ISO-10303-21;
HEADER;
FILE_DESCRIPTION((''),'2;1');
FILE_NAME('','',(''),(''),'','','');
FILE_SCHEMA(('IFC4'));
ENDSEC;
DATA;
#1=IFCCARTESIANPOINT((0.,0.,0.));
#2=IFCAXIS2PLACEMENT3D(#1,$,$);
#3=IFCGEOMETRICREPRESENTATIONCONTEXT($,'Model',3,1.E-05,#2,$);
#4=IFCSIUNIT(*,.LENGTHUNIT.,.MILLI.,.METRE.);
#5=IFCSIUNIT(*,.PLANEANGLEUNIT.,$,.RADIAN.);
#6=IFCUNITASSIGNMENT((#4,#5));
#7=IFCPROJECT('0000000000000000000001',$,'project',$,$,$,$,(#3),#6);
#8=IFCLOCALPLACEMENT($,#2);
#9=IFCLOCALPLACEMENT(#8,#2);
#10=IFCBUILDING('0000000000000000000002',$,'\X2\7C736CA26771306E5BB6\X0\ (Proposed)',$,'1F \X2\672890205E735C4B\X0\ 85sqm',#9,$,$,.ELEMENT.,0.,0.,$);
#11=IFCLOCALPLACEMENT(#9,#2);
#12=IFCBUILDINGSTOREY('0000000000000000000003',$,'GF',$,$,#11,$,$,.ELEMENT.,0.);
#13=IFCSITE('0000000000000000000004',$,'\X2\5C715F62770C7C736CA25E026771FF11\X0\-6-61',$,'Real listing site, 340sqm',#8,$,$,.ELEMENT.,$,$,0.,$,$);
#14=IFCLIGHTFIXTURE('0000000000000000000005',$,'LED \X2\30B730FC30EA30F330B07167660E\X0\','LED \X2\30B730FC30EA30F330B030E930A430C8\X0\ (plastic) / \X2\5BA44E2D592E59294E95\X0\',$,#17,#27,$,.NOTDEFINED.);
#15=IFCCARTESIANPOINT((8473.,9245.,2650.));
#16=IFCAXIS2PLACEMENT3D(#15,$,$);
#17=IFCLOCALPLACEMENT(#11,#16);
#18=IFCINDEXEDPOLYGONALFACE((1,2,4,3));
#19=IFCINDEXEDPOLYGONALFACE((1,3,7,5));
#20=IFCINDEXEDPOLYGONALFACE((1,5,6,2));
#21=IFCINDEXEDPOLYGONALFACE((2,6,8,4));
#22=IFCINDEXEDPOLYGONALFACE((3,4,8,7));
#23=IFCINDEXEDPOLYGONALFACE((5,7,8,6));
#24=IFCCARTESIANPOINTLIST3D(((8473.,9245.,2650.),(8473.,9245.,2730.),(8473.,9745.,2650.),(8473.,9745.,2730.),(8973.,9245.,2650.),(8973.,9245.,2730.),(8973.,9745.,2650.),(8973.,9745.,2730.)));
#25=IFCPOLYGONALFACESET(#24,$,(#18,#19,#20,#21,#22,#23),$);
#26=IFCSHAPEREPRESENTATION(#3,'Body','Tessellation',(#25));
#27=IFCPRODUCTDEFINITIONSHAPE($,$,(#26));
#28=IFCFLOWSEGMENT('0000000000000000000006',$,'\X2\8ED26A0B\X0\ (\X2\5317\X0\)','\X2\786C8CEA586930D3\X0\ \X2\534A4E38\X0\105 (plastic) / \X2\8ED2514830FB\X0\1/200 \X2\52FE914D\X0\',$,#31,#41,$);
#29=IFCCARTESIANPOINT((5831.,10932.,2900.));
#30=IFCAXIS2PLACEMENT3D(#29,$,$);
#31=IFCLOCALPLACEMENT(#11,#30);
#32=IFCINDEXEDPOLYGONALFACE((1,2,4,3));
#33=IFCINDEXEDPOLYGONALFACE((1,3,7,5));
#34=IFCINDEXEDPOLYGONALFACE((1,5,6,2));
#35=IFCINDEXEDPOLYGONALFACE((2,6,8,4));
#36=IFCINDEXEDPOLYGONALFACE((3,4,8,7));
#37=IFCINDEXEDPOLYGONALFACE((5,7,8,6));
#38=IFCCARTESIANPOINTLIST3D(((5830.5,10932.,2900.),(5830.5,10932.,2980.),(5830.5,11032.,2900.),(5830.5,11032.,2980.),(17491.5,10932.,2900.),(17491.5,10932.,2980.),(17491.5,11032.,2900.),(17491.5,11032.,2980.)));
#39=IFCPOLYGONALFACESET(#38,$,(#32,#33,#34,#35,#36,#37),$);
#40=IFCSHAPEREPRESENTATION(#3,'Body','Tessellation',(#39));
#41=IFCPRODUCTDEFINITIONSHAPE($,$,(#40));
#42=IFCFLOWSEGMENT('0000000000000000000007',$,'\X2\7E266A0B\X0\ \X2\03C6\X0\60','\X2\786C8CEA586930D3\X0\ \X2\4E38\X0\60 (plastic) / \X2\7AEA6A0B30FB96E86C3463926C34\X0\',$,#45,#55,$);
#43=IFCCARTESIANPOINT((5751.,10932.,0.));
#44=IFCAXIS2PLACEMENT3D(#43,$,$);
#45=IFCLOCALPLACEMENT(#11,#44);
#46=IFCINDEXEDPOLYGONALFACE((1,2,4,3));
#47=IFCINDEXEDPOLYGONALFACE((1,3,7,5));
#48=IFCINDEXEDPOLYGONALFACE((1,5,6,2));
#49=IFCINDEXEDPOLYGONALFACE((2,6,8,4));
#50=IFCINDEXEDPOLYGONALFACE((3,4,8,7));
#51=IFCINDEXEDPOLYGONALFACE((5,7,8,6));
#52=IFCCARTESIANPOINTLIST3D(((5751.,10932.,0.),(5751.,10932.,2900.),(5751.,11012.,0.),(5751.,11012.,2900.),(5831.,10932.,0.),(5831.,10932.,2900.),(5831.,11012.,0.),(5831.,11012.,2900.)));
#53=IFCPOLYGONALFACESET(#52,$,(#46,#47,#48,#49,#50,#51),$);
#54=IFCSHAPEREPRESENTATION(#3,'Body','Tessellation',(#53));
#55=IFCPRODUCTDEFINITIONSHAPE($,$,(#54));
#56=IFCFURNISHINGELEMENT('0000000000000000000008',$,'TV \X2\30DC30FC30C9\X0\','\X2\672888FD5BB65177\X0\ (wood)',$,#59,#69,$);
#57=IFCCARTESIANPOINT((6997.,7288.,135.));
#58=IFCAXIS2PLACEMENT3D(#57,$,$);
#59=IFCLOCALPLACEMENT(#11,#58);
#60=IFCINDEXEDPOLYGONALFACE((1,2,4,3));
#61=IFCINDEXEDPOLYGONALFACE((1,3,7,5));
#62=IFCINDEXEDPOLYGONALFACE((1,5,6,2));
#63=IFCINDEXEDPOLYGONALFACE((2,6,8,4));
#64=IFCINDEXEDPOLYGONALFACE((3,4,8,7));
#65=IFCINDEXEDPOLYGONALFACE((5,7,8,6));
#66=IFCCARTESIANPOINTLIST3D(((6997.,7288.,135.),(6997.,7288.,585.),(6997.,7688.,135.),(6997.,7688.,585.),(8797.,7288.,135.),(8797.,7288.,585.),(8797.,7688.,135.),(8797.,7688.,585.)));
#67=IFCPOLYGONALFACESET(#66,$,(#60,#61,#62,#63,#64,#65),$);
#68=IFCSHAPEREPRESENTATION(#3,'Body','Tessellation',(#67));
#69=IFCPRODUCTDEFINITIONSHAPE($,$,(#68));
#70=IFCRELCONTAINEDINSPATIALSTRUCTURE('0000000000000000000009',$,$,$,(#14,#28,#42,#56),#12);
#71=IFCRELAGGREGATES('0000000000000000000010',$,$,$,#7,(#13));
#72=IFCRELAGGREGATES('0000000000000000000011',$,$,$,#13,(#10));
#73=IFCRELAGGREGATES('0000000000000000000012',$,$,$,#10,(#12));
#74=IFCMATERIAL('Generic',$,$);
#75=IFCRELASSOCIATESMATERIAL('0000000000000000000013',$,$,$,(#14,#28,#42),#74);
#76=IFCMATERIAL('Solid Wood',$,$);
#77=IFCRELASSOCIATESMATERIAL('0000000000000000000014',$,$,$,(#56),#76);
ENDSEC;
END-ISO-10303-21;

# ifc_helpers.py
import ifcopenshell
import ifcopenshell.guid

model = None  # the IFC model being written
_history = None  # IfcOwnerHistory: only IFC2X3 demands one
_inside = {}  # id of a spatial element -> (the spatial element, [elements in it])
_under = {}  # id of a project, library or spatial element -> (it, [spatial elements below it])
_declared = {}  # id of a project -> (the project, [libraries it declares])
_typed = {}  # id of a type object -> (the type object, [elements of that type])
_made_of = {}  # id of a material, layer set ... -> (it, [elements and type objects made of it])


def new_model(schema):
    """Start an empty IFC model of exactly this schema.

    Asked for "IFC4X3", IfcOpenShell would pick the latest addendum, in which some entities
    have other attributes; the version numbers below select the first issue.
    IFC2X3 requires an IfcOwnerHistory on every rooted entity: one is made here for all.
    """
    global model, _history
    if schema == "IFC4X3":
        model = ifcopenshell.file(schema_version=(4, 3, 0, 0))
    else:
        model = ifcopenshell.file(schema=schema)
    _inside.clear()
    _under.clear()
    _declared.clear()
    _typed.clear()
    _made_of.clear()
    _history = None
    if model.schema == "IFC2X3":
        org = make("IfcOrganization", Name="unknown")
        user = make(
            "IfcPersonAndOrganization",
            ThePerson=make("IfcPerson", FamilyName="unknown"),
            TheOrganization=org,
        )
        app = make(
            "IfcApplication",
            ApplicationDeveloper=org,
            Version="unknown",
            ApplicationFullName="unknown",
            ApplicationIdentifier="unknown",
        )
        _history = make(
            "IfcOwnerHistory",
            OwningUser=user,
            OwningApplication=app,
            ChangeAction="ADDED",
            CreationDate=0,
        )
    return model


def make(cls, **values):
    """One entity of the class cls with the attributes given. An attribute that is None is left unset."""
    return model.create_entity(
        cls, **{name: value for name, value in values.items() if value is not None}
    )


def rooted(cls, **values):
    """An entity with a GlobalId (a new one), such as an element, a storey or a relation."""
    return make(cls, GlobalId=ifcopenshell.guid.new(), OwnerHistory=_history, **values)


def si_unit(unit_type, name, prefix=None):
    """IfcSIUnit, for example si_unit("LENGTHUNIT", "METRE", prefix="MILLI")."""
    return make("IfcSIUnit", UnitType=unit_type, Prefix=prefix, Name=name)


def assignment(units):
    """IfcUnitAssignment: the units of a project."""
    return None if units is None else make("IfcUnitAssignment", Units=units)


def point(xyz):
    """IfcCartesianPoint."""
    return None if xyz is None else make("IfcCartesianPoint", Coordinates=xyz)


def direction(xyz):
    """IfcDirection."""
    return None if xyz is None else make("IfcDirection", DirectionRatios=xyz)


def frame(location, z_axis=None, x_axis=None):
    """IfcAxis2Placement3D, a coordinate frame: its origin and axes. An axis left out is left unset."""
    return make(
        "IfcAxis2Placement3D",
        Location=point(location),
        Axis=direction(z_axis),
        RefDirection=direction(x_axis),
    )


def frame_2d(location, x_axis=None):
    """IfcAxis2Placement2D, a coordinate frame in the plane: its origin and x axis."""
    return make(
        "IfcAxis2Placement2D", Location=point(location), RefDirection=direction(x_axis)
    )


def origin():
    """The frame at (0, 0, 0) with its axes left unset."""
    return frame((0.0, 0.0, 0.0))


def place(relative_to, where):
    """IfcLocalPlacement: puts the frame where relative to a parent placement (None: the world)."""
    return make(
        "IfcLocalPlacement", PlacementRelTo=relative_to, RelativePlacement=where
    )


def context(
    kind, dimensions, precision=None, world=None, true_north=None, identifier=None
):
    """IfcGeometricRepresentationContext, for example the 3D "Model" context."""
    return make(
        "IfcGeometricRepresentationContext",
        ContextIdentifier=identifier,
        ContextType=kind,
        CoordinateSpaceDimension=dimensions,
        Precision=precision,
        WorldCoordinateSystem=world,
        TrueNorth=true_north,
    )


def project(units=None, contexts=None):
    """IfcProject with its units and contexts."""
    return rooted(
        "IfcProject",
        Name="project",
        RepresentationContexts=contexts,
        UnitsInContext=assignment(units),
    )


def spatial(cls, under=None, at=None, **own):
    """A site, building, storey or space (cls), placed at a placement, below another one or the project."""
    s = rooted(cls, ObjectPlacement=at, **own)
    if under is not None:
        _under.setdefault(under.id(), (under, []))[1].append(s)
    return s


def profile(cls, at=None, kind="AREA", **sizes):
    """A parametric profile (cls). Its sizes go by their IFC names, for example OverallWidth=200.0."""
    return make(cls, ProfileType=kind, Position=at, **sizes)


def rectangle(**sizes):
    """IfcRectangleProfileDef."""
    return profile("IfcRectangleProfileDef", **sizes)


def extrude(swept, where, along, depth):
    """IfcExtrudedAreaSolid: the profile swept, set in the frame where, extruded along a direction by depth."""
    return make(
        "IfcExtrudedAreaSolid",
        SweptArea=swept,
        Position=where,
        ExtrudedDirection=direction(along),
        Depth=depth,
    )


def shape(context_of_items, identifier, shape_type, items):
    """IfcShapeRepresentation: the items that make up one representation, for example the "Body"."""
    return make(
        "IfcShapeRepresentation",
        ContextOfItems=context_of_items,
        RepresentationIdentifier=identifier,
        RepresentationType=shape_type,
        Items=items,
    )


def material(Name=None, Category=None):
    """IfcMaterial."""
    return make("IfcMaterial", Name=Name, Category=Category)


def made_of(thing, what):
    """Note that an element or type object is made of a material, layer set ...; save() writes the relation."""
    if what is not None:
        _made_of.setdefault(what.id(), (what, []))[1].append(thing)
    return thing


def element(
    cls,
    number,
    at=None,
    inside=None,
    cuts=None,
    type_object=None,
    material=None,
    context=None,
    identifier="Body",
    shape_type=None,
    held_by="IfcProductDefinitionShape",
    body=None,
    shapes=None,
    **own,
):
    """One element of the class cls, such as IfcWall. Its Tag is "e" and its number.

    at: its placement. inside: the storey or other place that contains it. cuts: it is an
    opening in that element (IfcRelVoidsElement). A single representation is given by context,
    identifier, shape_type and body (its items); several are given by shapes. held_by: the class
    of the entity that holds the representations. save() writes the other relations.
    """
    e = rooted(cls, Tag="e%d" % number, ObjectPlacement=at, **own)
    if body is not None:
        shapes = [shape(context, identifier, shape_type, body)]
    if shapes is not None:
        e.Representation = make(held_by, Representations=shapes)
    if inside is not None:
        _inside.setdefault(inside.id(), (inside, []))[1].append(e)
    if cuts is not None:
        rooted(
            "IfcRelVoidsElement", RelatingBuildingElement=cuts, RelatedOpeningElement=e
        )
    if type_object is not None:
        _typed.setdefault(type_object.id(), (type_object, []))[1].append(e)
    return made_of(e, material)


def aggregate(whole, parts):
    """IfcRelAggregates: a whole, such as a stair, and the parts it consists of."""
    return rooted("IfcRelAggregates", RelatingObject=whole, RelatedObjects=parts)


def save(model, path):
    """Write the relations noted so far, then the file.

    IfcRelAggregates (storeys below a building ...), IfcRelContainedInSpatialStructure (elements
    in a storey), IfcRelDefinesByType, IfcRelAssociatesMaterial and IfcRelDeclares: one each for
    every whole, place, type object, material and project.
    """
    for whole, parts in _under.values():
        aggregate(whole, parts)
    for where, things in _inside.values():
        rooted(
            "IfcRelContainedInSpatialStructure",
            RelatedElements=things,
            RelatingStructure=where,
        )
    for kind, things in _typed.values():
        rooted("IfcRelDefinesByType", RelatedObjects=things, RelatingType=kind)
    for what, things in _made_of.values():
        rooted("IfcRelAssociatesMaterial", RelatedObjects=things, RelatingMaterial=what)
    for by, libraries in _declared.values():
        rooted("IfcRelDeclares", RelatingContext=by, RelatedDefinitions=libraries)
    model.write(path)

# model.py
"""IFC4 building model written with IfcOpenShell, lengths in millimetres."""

from ifc_helpers import new_model, si_unit, frame, frame_2d, origin, place, context, project, spatial, rectangle, extrude, material, element, save


model = new_model("IFC4")

# Units and contexts
model_context = context("Model", 3, precision=1e-05, world=origin())
ifc_project = project(units=[si_unit("LENGTHUNIT", "METRE", prefix="MILLI"), si_unit("PLANEANGLEUNIT", "RADIAN")], contexts=[model_context])

# Site, building, storey
site_placement = place(None, origin())
site = spatial("IfcSite", under=ifc_project, at=site_placement, Name="山形県米沢市東１-6-61", ObjectType="Real listing site, 340sqm", CompositionType="ELEMENT", RefElevation=0.0)
building_placement = place(site_placement, origin())
building = spatial("IfcBuilding", under=site, at=building_placement, Name="米沢東の家 (Proposed)", ObjectType="1F 木造平屋 85sqm", CompositionType="ELEMENT", ElevationOfRefHeight=0.0, ElevationOfTerrain=0.0)
storey_placement = place(building_placement, origin())
storey = spatial("IfcBuildingStorey", under=building, at=storey_placement, Name="GF", CompositionType="ELEMENT", Elevation=0.0)

# Shared definitions
ifc_material_1 = material(Name="Solid Wood")

# Shared definitions
ifc_material_2 = material(Name="Generic")

# Light fixture
light_fixture_placement = place(storey_placement, frame((8473.0, 9245.0, 2650.0)))
element("IfcLightFixture", 1, at=light_fixture_placement, inside=storey, material=ifc_material_2, Name="LED シーリング照明", Description="LED シーリングライト (plastic) / 室中央天井", PredefinedType="NOTDEFINED", context=model_context, shape_type="SweptSolid", body=[
    extrude(rectangle(XDim=500.0, YDim=500.0, at=frame_2d((250.0, 250.0))), frame((8473.0, 9245.0, 2650.0)), (0.0, 0.0, 1.0), 80.0),
])

# Flow segments
flow_segment_1_placement = place(storey_placement, frame((5831.0, 10932.0, 2900.0)))
element("IfcFlowSegment", 2, at=flow_segment_1_placement, inside=storey, material=ifc_material_2, Name="軒樋 (北)", Description="硬質塩ビ 半丸105 (plastic) / 軒先・1/200 勾配", context=model_context, shape_type="SweptSolid", body=[
    extrude(rectangle(XDim=11661.0, YDim=100.0, at=frame_2d((5830.0, 50.0))), frame((5831.0, 10932.0, 2900.0)), (0.0, 0.0, 1.0), 80.0),
])
flow_segment_2_placement = place(storey_placement, frame((5751.0, 10932.0, 0.0)))
element("IfcFlowSegment", 3, at=flow_segment_2_placement, inside=storey, material=ifc_material_2, Name="縦樋 φ60", Description="硬質塩ビ 丸60 (plastic) / 竪樋・雨水排水", context=model_context, shape_type="SweptSolid", body=[
    extrude(rectangle(XDim=80.0, YDim=80.0, at=frame_2d((40.0, 40.0))), frame((5751.0, 10932.0, 0.0)), (0.0, 0.0, 1.0), 2900.0),
])

# Furnishing element
furnishing_placement = place(storey_placement, frame((6997.0, 7288.0, 135.0)))
element("IfcFurnishingElement", 4, at=furnishing_placement, inside=storey, material=ifc_material_1, Name="TV ボード", Description="木製家具 (wood)", context=model_context, shape_type="SweptSolid", body=[
    extrude(rectangle(XDim=1800.0, YDim=400.0, at=frame_2d((900.0, 200.0))), frame((6997.0, 7288.0, 135.0)), (0.0, 0.0, 1.0), 450.0),
])

save(model, "model.ifc")
